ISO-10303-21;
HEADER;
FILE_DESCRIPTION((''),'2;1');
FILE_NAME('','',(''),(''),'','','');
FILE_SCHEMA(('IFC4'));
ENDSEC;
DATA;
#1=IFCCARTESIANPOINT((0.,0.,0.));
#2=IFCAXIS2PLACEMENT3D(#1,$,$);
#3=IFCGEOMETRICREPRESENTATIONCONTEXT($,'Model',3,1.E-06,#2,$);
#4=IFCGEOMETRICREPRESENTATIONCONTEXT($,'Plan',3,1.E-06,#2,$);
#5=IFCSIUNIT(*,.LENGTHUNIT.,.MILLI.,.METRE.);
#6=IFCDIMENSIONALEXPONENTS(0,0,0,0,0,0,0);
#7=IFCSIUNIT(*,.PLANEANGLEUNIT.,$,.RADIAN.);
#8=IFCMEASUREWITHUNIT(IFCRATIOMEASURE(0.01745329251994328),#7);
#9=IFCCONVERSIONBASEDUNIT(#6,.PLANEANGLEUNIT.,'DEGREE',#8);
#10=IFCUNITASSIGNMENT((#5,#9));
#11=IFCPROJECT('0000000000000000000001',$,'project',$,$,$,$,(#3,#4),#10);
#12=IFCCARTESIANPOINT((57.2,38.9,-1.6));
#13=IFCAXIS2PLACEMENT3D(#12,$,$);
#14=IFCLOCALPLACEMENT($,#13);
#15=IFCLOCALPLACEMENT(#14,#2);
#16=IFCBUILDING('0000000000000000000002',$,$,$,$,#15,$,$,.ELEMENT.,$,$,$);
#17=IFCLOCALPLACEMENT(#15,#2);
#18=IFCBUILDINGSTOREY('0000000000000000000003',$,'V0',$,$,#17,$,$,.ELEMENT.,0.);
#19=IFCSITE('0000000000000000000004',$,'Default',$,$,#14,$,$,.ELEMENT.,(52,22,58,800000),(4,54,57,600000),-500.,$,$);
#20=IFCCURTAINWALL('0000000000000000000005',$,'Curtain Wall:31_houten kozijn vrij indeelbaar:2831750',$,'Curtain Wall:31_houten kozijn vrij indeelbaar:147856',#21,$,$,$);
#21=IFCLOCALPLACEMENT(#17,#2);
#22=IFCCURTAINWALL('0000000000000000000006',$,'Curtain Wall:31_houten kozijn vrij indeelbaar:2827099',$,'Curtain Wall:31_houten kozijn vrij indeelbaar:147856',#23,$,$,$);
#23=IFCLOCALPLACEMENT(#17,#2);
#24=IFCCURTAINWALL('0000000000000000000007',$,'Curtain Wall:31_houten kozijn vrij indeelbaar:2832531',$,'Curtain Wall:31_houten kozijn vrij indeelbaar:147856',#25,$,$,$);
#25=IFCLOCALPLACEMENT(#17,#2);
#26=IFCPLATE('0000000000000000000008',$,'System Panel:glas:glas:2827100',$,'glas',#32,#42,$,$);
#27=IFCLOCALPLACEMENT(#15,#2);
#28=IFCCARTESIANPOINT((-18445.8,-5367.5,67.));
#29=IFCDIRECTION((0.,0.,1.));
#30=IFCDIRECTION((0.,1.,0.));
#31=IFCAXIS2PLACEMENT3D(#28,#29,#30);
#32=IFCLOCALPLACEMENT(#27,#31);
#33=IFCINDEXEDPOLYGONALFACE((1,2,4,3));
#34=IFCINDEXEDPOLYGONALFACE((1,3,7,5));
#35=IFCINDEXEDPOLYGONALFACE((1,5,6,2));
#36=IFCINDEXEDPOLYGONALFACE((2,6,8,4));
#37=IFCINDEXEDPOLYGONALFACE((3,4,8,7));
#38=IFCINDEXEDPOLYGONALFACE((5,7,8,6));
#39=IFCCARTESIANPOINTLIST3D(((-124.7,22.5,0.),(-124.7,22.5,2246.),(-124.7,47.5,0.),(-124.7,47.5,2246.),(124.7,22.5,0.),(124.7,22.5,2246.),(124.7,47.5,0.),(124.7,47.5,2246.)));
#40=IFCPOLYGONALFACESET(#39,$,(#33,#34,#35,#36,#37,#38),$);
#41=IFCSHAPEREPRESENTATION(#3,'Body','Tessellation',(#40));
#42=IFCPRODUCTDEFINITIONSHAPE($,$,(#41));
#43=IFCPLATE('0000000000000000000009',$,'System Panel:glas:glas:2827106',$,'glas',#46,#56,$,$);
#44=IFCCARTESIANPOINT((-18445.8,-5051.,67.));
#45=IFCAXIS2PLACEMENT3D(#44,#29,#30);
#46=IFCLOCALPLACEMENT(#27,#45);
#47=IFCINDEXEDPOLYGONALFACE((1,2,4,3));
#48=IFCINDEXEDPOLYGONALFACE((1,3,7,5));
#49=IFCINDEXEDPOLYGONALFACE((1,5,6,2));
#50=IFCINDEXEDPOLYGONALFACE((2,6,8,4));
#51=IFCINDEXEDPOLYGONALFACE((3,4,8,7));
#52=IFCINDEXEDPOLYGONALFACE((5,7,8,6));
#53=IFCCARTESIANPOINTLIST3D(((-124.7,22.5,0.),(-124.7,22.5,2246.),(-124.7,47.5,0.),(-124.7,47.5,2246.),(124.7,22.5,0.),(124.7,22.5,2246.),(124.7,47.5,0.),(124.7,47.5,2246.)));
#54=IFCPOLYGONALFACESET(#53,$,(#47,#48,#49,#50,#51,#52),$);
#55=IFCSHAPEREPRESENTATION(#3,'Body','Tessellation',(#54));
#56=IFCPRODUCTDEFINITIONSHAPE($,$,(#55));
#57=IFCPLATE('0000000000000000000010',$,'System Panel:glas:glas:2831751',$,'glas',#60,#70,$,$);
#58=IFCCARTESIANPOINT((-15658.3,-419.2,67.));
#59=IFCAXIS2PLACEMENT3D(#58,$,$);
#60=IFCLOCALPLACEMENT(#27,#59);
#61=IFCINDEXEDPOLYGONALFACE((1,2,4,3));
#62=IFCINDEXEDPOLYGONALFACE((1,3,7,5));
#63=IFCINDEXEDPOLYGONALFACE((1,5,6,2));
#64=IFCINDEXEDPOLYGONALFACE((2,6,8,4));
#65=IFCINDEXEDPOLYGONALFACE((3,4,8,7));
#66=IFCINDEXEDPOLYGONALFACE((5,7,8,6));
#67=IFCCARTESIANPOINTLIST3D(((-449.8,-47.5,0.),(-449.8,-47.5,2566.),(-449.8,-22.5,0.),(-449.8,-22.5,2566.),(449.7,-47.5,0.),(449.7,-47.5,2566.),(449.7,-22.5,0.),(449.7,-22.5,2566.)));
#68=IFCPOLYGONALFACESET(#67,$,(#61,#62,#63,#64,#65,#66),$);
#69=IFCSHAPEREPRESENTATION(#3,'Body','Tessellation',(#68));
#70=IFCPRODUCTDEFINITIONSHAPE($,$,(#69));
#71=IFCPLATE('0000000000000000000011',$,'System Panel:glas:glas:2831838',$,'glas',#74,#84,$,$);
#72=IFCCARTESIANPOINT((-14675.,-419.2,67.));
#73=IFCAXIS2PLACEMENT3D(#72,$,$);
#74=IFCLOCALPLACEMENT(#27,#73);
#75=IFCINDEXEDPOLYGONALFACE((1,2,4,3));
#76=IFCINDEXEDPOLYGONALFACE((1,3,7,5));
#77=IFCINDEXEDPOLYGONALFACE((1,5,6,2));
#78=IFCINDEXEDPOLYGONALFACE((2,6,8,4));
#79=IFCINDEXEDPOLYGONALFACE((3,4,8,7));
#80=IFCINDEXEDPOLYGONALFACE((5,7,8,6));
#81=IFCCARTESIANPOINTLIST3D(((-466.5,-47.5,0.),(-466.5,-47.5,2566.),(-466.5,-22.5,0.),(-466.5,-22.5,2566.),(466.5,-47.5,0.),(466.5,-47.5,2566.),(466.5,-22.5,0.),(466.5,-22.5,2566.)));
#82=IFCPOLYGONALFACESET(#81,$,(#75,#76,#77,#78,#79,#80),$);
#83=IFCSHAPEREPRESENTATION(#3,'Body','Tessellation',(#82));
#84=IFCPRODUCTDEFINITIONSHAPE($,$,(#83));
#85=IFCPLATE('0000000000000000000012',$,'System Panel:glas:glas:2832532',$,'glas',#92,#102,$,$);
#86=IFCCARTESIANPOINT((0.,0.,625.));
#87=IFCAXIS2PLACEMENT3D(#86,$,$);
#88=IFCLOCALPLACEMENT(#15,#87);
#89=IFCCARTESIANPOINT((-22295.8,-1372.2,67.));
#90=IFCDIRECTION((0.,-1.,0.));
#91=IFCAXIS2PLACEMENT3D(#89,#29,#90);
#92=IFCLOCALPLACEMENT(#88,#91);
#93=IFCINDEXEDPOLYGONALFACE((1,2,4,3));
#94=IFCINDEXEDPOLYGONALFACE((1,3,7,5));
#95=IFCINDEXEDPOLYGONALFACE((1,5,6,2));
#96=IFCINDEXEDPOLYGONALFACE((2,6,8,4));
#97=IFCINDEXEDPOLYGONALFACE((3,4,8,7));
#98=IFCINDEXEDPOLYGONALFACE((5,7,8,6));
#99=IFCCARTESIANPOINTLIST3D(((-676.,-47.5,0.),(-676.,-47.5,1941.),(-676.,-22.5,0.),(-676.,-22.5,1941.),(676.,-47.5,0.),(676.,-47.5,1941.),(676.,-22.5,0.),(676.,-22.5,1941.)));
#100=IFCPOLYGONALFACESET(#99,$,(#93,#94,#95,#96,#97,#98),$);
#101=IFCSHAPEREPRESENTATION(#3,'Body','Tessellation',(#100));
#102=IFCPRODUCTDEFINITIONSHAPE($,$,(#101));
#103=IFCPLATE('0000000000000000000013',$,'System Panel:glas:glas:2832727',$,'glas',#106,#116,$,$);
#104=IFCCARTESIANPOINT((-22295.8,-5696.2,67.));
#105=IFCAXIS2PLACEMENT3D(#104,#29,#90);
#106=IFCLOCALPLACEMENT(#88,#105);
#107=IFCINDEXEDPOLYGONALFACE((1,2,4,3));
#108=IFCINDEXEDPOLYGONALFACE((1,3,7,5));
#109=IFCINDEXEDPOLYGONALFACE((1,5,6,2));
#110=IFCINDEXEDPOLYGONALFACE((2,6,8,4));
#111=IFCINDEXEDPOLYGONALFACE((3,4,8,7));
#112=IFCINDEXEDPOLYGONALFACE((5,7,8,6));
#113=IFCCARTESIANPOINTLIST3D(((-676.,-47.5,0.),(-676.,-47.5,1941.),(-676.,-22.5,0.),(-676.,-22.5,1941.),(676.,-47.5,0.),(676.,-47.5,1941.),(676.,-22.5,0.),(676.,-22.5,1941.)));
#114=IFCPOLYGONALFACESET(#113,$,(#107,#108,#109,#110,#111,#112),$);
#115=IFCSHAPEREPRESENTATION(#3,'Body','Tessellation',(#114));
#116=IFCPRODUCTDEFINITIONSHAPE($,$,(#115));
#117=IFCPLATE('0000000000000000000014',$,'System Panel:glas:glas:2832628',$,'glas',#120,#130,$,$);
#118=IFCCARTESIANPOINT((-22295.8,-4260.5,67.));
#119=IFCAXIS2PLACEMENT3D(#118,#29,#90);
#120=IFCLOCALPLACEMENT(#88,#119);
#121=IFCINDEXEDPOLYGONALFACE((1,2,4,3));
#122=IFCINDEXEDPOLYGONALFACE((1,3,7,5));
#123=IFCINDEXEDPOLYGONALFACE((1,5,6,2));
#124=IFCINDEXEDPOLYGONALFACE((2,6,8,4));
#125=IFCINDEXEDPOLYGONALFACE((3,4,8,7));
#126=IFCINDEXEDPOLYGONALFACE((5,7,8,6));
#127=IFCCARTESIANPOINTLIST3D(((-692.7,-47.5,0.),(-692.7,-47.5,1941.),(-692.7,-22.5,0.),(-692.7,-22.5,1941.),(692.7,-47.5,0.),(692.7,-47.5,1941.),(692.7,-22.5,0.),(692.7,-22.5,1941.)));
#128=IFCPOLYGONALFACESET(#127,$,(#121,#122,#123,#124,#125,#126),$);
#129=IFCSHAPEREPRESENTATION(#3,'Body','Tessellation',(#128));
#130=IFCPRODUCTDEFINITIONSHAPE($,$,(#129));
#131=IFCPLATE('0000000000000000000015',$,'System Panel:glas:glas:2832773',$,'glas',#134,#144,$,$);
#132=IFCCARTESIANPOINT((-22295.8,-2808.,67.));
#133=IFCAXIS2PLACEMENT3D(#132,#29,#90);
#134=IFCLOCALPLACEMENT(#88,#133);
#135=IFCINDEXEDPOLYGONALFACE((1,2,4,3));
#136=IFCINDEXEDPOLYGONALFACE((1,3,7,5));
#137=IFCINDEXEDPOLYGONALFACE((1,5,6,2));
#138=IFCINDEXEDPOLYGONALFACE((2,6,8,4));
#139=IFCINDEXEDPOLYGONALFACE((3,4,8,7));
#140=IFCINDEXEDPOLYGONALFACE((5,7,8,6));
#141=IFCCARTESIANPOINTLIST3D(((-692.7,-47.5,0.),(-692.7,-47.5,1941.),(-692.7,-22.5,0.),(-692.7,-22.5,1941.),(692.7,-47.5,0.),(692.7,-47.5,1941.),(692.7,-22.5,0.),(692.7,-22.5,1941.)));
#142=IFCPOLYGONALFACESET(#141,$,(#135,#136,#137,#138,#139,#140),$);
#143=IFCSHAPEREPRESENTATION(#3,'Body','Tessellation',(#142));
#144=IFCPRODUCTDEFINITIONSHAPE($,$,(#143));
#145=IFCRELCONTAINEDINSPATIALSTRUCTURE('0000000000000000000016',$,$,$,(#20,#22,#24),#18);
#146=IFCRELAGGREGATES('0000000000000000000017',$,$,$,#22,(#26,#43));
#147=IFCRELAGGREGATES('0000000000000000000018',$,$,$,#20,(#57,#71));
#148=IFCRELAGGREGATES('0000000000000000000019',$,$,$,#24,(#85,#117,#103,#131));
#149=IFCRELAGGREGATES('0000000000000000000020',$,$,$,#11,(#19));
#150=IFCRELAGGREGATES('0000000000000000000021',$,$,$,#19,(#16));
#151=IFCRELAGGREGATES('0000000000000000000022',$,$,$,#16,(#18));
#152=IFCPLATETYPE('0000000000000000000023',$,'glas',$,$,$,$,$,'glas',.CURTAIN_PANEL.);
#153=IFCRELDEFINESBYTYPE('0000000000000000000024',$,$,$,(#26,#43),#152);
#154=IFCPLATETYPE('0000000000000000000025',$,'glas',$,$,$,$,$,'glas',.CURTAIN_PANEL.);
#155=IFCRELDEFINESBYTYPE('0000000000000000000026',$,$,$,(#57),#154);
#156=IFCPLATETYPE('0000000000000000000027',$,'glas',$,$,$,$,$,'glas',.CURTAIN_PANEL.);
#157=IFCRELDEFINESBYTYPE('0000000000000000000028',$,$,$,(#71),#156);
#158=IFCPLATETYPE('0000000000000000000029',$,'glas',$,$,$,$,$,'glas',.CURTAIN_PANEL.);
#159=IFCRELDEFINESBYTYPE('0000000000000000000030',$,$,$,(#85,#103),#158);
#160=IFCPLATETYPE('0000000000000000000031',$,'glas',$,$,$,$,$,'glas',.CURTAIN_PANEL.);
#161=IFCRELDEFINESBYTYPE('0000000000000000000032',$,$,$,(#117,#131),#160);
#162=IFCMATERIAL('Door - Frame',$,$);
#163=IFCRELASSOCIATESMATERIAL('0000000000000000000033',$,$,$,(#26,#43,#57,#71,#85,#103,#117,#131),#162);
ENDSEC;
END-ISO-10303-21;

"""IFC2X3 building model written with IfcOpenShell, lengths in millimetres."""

from ifc_helpers import new_model, entity, si_unit, converted_unit, frame, origin, origin_2d_with_axis, place, context, project, spatial, rectangle, extrude, source, transform, mapped, material, type_object, type_shapes, element, aggregate, save


model = new_model("IFC2X3")

# Units and contexts
model_context = context("Model", 3, precision=1e-06, world=origin())
plan_context = context("Plan", 3, precision=1e-06, world=origin())
ifc_project = project(units=[si_unit("LENGTHUNIT", "METRE", prefix="MILLI"), converted_unit("PLANEANGLEUNIT", "DEGREE", entity("IfcRatioMeasure", 0.01745329251994328), si_unit("PLANEANGLEUNIT", "RADIAN"), dimensions=[0, 0, 0, 0, 0, 0, 0])], contexts=[model_context, plan_context])

# Site, building, storey
site_placement = place(None, frame((57.2, 38.9, -1.6)))
site = spatial("IfcSite", under=ifc_project, at=site_placement, Name="Default", CompositionType="ELEMENT", RefLatitude=(52, 22, 58, 800000), RefLongitude=(4, 54, 57, 600000), RefElevation=-500.0)
building_placement = place(site_placement, origin())
building = spatial("IfcBuilding", under=site, at=building_placement, CompositionType="ELEMENT")
storey_placement = place(building_placement, origin())
storey = spatial("IfcBuildingStorey", under=building, at=storey_placement, Name="V0", CompositionType="ELEMENT", Elevation=0.0)

# Curtain walls
curtain_wall_1_placement = place(storey_placement, origin())
curtain_wall_1 = element("IfcCurtainWall", 1, at=curtain_wall_1_placement, inside=storey, Name="Curtain Wall:31_houten kozijn vrij indeelbaar:2831750", ObjectType="Curtain Wall:31_houten kozijn vrij indeelbaar:147856")
placement_1 = place(building_placement, origin())
curtain_wall_2_placement = place(storey_placement, origin())
curtain_wall_2 = element("IfcCurtainWall", 2, at=curtain_wall_2_placement, inside=storey, Name="Curtain Wall:31_houten kozijn vrij indeelbaar:2827099", ObjectType="Curtain Wall:31_houten kozijn vrij indeelbaar:147856")
placement_2 = place(building_placement, frame((0.0, 0.0, 625.0)))

# Curtain wall
curtain_wall_3_placement = place(storey_placement, origin())
curtain_wall_3 = element("IfcCurtainWall", 3, at=curtain_wall_3_placement, inside=storey, Name="Curtain Wall:31_houten kozijn vrij indeelbaar:2832531", ObjectType="Curtain Wall:31_houten kozijn vrij indeelbaar:147856")

# Plates
ifc_material_1 = material(Name="Door - Frame")
plate_type_1 = type_object("IfcPlateType", Name="glas", ElementType="glas", PredefinedType="CURTAIN_PANEL")
shared_shape_1 = source(origin(), model_context, "Body", "SweptSolid", [
    extrude(rectangle(XDim=25.0, YDim=249.5, at=origin_2d_with_axis()), frame((0.0, 35.0, 0.0), z_axis=(0.0, 0.0, 1.0), x_axis=(0.0, 1.0, 0.0)), (0.0, 0.0, 1.0), 2246.0),
])
type_shapes(plate_type_1, [shared_shape_1])
plate_1_placement = place(placement_1, frame((-18445.8, -5367.5, 67.0), z_axis=(0.0, 0.0, 1.0), x_axis=(0.0, 1.0, 0.0)))
plate_1 = element("IfcPlate", 4, at=plate_1_placement, type_object=plate_type_1, material=ifc_material_1, Name="System Panel:glas:glas:2827100", ObjectType="glas", context=model_context, shape_type="MappedRepresentation", body=[
    mapped(shared_shape_1, transform((0.0, 0.0, 0.0), scale=1.0)),
])
plate_2_placement = place(placement_1, frame((-18445.8, -5051.0, 67.0), z_axis=(0.0, 0.0, 1.0), x_axis=(0.0, 1.0, 0.0)))
plate_2 = element("IfcPlate", 5, at=plate_2_placement, type_object=plate_type_1, material=ifc_material_1, Name="System Panel:glas:glas:2827106", ObjectType="glas", context=model_context, shape_type="MappedRepresentation", body=[
    mapped(shared_shape_1, transform((0.0, 0.0, 0.0), scale=1.0)),
])
aggregate(curtain_wall_2, [plate_1, plate_2])
plate_type_2 = type_object("IfcPlateType", Name="glas", ElementType="glas", PredefinedType="CURTAIN_PANEL")
shared_shape_2 = source(origin(), model_context, "Body", "SweptSolid", [
    extrude(rectangle(XDim=25.0, YDim=899.5, at=origin_2d_with_axis()), frame((0.0, -35.0, 0.0), z_axis=(0.0, 0.0, 1.0), x_axis=(0.0, 1.0, 0.0)), (0.0, 0.0, 1.0), 2566.0),
])
type_shapes(plate_type_2, [shared_shape_2])
plate_3_placement = place(placement_1, frame((-15658.3, -419.2, 67.0)))
plate_3 = element("IfcPlate", 6, at=plate_3_placement, type_object=plate_type_2, material=ifc_material_1, Name="System Panel:glas:glas:2831751", ObjectType="glas", context=model_context, shape_type="MappedRepresentation", body=[
    mapped(shared_shape_2, transform((0.0, 0.0, 0.0), scale=1.0)),
])
plate_type_3 = type_object("IfcPlateType", Name="glas", ElementType="glas", PredefinedType="CURTAIN_PANEL")
shared_shape_3 = source(origin(), model_context, "Body", "SweptSolid", [
    extrude(rectangle(XDim=25.0, YDim=933.0, at=origin_2d_with_axis()), frame((0.0, -35.0, 0.0), z_axis=(0.0, 0.0, 1.0), x_axis=(0.0, 1.0, 0.0)), (0.0, 0.0, 1.0), 2566.0),
])
type_shapes(plate_type_3, [shared_shape_3])
plate_4_placement = place(placement_1, frame((-14675.0, -419.2, 67.0)))
plate_4 = element("IfcPlate", 7, at=plate_4_placement, type_object=plate_type_3, material=ifc_material_1, Name="System Panel:glas:glas:2831838", ObjectType="glas", context=model_context, shape_type="MappedRepresentation", body=[
    mapped(shared_shape_3, transform((0.0, 0.0, 0.0), scale=1.0)),
])
aggregate(curtain_wall_1, [plate_3, plate_4])
plate_type_4 = type_object("IfcPlateType", Name="glas", ElementType="glas", PredefinedType="CURTAIN_PANEL")
shared_shape_4 = source(origin(), model_context, "Body", "SweptSolid", [
    extrude(rectangle(XDim=25.0, YDim=1352.0, at=origin_2d_with_axis()), frame((0.0, -35.0, 0.0), z_axis=(0.0, 0.0, 1.0), x_axis=(0.0, 1.0, 0.0)), (0.0, 0.0, 1.0), 1941.0),
])
type_shapes(plate_type_4, [shared_shape_4])
plate_5_placement = place(placement_2, frame((-22295.8, -1372.2, 67.0), z_axis=(0.0, 0.0, 1.0), x_axis=(0.0, -1.0, 0.0)))
plate_5 = element("IfcPlate", 8, at=plate_5_placement, type_object=plate_type_4, material=ifc_material_1, Name="System Panel:glas:glas:2832532", ObjectType="glas", context=model_context, shape_type="MappedRepresentation", body=[
    mapped(shared_shape_4, transform((0.0, 0.0, 0.0), scale=1.0)),
])
plate_6_placement = place(placement_2, frame((-22295.8, -5696.2, 67.0), z_axis=(0.0, 0.0, 1.0), x_axis=(0.0, -1.0, 0.0)))
plate_6 = element("IfcPlate", 9, at=plate_6_placement, type_object=plate_type_4, material=ifc_material_1, Name="System Panel:glas:glas:2832727", ObjectType="glas", context=model_context, shape_type="MappedRepresentation", body=[
    mapped(shared_shape_4, transform((0.0, 0.0, 0.0), scale=1.0)),
])
plate_type_5 = type_object("IfcPlateType", Name="glas", ElementType="glas", PredefinedType="CURTAIN_PANEL")
shared_shape_5 = source(origin(), model_context, "Body", "SweptSolid", [
    extrude(rectangle(XDim=25.0, YDim=1385.5, at=origin_2d_with_axis()), frame((0.0, -35.0, 0.0), z_axis=(0.0, 0.0, 1.0), x_axis=(0.0, 1.0, 0.0)), (0.0, 0.0, 1.0), 1941.0),
])
type_shapes(plate_type_5, [shared_shape_5])
plate_7_placement = place(placement_2, frame((-22295.8, -4260.5, 67.0), z_axis=(0.0, 0.0, 1.0), x_axis=(0.0, -1.0, 0.0)))
plate_7 = element("IfcPlate", 10, at=plate_7_placement, type_object=plate_type_5, material=ifc_material_1, Name="System Panel:glas:glas:2832628", ObjectType="glas", context=model_context, shape_type="MappedRepresentation", body=[
    mapped(shared_shape_5, transform((0.0, 0.0, 0.0), scale=1.0)),
])
plate_8_placement = place(placement_2, frame((-22295.8, -2808.0, 67.0), z_axis=(0.0, 0.0, 1.0), x_axis=(0.0, -1.0, 0.0)))
plate_8 = element("IfcPlate", 11, at=plate_8_placement, type_object=plate_type_5, material=ifc_material_1, Name="System Panel:glas:glas:2832773", ObjectType="glas", context=model_context, shape_type="MappedRepresentation", body=[
    mapped(shared_shape_5, transform((0.0, 0.0, 0.0), scale=1.0)),
])
aggregate(curtain_wall_3, [plate_5, plate_7, plate_6, plate_8])

save(model, "model.ifc")
